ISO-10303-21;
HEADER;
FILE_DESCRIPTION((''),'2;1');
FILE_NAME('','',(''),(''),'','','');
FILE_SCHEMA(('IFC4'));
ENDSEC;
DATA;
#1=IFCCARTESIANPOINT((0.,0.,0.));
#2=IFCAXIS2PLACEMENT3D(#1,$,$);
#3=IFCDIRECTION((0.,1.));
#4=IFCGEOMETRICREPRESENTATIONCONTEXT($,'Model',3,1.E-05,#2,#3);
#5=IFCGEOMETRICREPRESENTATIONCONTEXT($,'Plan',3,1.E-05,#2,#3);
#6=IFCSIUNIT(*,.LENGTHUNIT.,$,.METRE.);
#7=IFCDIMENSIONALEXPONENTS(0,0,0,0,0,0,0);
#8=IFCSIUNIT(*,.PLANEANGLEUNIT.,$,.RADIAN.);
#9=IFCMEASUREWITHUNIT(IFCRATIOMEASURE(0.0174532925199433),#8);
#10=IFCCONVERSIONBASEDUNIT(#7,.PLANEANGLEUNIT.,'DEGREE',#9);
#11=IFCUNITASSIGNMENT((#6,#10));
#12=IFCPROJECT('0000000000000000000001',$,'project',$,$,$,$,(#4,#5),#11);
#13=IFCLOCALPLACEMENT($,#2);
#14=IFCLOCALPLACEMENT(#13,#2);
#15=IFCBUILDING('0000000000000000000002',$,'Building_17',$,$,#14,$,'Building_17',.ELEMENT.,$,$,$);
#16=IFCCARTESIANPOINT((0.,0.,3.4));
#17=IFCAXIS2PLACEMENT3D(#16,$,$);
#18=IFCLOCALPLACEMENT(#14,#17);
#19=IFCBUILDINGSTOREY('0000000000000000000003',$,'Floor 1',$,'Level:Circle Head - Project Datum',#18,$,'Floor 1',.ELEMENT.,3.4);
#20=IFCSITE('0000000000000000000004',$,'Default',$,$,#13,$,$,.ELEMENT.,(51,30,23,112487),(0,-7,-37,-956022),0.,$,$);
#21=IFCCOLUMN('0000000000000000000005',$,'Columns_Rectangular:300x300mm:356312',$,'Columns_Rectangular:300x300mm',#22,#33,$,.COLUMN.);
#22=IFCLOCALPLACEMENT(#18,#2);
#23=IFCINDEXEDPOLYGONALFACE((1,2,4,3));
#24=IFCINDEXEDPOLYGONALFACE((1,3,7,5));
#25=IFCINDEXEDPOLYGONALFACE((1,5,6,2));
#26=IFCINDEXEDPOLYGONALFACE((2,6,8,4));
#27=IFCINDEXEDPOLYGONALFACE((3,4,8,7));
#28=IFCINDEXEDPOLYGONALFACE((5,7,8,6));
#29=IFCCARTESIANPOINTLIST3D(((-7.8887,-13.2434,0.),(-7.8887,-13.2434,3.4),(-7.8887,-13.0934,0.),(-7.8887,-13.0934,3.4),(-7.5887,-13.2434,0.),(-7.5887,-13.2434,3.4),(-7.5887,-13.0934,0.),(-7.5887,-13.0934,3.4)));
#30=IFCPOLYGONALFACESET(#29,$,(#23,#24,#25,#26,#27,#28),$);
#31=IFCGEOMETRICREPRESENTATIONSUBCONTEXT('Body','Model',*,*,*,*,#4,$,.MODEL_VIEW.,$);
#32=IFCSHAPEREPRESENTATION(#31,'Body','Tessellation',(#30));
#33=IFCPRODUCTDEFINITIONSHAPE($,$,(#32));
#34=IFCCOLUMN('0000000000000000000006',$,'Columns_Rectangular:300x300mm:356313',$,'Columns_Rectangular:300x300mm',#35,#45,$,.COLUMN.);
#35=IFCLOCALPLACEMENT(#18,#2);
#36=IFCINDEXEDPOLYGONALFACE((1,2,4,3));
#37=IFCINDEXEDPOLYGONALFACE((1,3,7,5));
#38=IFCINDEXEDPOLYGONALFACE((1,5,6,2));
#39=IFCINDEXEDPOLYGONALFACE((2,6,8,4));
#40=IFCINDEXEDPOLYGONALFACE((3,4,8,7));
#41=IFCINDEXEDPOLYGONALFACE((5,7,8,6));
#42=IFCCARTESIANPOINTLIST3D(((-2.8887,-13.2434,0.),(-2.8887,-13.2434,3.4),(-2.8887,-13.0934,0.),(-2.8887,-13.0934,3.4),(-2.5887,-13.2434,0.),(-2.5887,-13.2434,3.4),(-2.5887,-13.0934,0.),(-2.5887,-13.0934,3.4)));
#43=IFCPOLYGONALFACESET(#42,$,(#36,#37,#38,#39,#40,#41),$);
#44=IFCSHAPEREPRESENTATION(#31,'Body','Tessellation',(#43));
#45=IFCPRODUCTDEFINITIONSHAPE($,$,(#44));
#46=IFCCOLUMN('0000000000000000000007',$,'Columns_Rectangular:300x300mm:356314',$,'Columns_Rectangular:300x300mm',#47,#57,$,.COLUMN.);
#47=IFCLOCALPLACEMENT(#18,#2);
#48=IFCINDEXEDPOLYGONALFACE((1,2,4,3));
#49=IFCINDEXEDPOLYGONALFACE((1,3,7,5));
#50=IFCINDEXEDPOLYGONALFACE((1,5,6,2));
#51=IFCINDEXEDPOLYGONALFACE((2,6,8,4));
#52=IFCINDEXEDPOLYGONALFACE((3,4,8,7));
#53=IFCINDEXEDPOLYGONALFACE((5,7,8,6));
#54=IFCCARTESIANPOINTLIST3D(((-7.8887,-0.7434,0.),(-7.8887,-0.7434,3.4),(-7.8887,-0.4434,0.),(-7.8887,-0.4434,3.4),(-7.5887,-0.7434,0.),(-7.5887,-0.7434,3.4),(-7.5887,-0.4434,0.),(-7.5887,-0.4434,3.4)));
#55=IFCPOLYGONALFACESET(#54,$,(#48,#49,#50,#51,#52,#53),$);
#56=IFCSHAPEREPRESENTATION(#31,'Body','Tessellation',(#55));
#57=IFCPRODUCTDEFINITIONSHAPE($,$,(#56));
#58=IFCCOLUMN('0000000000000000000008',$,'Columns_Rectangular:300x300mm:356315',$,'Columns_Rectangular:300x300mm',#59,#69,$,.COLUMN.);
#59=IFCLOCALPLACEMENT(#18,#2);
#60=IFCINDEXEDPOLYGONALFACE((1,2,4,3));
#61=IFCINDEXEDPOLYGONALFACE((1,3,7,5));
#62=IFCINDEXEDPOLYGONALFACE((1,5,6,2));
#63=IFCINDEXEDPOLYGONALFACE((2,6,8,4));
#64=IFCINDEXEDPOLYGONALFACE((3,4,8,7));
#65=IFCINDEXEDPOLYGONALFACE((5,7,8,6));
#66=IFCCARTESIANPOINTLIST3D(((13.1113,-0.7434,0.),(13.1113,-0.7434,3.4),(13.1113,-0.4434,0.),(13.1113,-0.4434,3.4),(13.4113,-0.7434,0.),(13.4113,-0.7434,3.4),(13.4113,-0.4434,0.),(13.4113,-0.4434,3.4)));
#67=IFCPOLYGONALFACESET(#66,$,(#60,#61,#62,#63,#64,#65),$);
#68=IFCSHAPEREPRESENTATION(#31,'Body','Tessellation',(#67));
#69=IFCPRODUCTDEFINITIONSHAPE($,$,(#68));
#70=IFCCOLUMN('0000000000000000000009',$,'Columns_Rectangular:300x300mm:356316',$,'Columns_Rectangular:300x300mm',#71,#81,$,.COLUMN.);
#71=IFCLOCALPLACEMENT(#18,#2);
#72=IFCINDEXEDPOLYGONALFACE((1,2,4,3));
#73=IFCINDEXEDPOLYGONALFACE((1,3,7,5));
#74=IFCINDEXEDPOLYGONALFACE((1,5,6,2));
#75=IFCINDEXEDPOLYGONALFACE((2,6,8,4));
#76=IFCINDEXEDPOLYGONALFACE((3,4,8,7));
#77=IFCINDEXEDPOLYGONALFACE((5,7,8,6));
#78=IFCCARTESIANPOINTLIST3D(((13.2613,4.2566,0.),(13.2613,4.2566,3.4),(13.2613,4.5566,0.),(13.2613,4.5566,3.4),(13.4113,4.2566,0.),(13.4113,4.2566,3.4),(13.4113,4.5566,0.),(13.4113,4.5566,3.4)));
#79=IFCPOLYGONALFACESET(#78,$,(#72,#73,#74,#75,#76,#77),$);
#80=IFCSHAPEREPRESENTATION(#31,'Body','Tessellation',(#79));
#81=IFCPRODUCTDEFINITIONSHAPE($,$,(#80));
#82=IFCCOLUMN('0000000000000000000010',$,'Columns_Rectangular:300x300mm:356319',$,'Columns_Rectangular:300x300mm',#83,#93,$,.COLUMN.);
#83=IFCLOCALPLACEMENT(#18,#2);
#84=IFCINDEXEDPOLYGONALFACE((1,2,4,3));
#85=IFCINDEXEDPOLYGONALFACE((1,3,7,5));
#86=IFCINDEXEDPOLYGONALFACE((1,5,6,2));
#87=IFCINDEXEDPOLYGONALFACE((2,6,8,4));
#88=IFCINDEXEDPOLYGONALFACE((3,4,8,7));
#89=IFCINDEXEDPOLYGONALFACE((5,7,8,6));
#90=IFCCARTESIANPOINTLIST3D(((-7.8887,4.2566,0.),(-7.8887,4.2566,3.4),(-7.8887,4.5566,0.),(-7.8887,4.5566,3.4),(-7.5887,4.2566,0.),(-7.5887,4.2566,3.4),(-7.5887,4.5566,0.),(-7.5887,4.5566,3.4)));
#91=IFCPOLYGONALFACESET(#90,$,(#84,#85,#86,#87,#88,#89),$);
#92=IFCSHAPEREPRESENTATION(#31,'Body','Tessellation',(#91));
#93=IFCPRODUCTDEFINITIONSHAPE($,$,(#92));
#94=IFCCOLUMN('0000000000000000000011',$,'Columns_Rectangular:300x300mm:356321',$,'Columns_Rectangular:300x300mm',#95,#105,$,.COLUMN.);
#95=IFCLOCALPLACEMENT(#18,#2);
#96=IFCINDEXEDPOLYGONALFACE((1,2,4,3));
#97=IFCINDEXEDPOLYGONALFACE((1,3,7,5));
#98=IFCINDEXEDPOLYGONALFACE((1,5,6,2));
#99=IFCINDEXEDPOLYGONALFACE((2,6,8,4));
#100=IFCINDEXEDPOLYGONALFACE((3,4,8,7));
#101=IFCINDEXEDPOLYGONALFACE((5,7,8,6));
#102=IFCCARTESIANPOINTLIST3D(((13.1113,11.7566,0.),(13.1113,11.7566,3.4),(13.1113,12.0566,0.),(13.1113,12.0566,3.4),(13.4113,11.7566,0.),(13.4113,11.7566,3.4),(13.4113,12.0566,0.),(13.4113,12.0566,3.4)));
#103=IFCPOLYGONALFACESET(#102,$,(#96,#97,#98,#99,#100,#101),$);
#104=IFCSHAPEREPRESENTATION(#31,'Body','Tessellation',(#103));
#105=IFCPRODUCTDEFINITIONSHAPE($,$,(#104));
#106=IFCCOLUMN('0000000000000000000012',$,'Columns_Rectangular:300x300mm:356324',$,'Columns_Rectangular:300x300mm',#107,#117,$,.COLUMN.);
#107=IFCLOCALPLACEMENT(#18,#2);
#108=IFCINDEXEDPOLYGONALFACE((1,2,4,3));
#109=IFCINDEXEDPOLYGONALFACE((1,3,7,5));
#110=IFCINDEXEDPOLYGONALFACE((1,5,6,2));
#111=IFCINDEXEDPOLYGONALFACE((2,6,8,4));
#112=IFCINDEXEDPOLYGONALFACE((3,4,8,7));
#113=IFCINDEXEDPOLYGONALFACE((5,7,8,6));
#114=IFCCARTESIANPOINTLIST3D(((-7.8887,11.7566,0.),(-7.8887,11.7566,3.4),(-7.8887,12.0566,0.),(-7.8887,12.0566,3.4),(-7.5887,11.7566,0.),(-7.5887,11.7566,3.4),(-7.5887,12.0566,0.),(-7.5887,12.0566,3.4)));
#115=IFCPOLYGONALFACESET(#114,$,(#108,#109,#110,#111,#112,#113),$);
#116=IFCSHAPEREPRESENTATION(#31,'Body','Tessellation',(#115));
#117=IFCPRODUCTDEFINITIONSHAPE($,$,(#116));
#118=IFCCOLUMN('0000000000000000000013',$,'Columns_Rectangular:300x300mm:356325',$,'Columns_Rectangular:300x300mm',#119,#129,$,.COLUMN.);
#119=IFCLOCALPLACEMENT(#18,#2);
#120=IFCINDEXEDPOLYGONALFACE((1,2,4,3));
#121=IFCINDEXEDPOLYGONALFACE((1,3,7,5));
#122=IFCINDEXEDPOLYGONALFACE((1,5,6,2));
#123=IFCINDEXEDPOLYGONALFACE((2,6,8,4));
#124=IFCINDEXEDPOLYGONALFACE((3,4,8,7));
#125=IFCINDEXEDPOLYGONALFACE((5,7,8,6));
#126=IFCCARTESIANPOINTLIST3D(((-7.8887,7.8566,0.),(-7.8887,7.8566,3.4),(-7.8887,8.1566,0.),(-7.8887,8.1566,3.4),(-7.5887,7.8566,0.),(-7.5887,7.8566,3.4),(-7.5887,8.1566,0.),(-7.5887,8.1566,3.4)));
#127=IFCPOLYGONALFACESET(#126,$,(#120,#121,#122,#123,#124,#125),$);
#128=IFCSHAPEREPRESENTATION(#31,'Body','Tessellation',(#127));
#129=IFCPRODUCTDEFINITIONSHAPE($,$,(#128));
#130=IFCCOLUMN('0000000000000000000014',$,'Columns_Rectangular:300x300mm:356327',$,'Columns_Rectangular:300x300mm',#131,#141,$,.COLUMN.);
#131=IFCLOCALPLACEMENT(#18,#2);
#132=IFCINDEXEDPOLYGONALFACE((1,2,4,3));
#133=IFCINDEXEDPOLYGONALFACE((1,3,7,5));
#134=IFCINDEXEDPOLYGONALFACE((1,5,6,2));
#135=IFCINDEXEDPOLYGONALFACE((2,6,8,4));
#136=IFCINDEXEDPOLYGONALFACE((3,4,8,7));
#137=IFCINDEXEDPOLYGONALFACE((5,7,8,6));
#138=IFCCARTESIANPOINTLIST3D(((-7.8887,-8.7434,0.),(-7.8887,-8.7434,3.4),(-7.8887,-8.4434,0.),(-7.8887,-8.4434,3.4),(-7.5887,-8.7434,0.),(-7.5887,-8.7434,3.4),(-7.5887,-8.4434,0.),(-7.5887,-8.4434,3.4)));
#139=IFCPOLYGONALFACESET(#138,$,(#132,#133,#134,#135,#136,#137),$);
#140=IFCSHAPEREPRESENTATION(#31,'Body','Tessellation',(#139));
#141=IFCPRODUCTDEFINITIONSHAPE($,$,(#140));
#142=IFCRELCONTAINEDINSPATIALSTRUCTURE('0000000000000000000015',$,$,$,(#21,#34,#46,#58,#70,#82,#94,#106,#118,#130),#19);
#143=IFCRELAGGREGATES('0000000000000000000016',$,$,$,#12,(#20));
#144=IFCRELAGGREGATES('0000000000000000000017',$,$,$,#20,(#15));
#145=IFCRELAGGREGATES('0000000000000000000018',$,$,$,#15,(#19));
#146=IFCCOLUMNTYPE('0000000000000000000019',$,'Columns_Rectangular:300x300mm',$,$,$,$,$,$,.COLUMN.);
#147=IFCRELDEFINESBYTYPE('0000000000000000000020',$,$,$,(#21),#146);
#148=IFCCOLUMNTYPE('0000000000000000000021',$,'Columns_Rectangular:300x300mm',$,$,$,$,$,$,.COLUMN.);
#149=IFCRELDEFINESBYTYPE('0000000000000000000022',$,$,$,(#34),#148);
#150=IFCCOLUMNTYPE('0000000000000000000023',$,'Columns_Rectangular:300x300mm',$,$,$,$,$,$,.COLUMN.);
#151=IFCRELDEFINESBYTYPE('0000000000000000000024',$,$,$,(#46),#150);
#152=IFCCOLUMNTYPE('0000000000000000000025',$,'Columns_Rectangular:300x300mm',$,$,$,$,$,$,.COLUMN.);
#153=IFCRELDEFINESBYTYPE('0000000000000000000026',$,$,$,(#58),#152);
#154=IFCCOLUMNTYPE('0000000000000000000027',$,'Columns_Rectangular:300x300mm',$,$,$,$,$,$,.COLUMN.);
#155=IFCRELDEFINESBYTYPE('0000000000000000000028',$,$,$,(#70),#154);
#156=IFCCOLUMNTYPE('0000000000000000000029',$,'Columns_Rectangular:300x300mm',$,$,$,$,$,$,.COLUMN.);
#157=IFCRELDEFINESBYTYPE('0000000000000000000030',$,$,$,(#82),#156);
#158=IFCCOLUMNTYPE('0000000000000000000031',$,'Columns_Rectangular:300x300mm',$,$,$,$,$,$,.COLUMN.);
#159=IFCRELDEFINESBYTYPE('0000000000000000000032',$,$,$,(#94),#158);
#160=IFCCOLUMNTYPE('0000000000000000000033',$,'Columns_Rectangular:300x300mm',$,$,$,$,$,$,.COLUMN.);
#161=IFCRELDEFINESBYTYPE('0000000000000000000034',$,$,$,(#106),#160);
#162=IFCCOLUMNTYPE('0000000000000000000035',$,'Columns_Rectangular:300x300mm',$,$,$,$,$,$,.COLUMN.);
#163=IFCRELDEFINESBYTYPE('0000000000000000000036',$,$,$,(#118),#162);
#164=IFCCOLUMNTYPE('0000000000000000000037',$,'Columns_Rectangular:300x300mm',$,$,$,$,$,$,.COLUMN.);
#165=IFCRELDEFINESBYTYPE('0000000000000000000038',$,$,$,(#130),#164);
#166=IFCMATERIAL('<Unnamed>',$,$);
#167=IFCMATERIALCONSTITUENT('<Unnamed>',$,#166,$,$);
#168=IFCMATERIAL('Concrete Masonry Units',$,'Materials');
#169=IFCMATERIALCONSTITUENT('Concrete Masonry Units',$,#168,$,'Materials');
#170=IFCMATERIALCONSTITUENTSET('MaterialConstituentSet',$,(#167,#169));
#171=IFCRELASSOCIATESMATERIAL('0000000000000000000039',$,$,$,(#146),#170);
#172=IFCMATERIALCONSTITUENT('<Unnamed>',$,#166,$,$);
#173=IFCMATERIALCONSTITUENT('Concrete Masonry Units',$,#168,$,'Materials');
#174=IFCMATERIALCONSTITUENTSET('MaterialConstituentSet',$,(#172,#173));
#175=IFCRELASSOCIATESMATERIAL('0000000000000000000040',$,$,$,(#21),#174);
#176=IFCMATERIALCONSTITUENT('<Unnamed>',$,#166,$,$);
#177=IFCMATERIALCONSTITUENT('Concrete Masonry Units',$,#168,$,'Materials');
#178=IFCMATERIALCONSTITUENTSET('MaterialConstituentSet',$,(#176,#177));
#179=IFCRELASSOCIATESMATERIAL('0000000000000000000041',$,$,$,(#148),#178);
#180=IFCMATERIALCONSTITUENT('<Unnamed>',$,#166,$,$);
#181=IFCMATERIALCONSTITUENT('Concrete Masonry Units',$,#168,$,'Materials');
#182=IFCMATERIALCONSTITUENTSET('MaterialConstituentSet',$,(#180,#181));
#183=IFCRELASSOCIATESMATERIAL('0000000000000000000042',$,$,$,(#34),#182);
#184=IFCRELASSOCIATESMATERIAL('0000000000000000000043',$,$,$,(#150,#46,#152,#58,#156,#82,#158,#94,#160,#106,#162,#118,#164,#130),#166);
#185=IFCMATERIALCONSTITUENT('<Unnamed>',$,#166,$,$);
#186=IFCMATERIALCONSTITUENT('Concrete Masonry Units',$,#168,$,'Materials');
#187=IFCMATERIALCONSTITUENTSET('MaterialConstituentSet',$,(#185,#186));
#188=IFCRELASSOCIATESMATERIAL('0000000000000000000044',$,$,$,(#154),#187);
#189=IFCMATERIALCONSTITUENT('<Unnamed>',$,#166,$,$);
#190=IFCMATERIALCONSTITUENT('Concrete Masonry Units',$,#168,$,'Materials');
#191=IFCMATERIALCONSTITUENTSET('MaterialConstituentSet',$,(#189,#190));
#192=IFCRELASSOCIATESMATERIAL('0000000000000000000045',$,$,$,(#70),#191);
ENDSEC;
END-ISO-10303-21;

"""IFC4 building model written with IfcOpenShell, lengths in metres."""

from ifc_helpers import new_model, entity, si_unit, converted_unit, direction, frame, origin, place, context, subcontext, project, spatial, indexed_curve, outline, extrude, source, transform, mapped, material, constituent, constituent_set, type_object, type_shapes, element, save


model = new_model("IFC4")

# Units and contexts
model_context = context("Model", 3, precision=1e-05, world=origin(), true_north=direction((0.0, 1.0)))
plan_context = context("Plan", 3, precision=1e-05, world=origin(), true_north=direction((0.0, 1.0)))
body_context = subcontext(model_context, "Body", "Model", "MODEL_VIEW")
ifc_project = project(units=[si_unit("LENGTHUNIT", "METRE"), converted_unit("PLANEANGLEUNIT", "DEGREE", entity("IfcRatioMeasure", 0.0174532925199433), si_unit("PLANEANGLEUNIT", "RADIAN"), dimensions=[0, 0, 0, 0, 0, 0, 0])], contexts=[model_context, plan_context])

# Site, building, storey
site_placement = place(None, origin())
site = spatial("IfcSite", under=ifc_project, at=site_placement, Name="Default", CompositionType="ELEMENT", RefLatitude=(51, 30, 23, 112487), RefLongitude=(0, -7, -37, -956022), RefElevation=0.0)
building_placement = place(site_placement, origin())
building = spatial("IfcBuilding", under=site, at=building_placement, Name="Building_17", LongName="Building_17", CompositionType="ELEMENT")
storey_placement = place(building_placement, frame((0.0, 0.0, 3.4)))
storey = spatial("IfcBuildingStorey", under=building, at=storey_placement, Name="Floor 1", ObjectType="Level:Circle Head - Project Datum", LongName="Floor 1", CompositionType="ELEMENT", Elevation=3.4)

# Columns
ifc_material_1 = material(Name="<Unnamed>")
ifc_constituent_1 = constituent(ifc_material_1, Name="<Unnamed>")
ifc_material_2 = material(Name="Concrete Masonry Units", Category="Materials")
ifc_constituent_2 = constituent(ifc_material_2, Name="Concrete Masonry Units", Category="Materials")
ifc_constituent_set_1 = constituent_set(constituents=[ifc_constituent_1, ifc_constituent_2], Name="MaterialConstituentSet")
ifc_constituent_3 = constituent(ifc_material_1, Name="<Unnamed>")
ifc_constituent_4 = constituent(ifc_material_2, Name="Concrete Masonry Units", Category="Materials")
ifc_constituent_set_2 = constituent_set(constituents=[ifc_constituent_3, ifc_constituent_4], Name="MaterialConstituentSet")
column_type_1 = type_object("IfcColumnType", Name="Columns_Rectangular:300x300mm", PredefinedType="COLUMN", material=ifc_constituent_set_2)
shared_shape_1 = source(origin(), body_context, "Body", "SweptSolid", [
    extrude(outline(indexed_curve([(-0.075, -0.15), (0.075, -0.15), (0.075, 0.15), (-0.075, 0.15), (-0.075, -0.15)], self_intersect=False)), frame((-7.7387, -13.1684, 3.4), z_axis=(0.0, 0.0, 1.0), x_axis=(0.0, -1.0, 0.0)), (0.0, 0.0, 1.0), 3.4),
])
type_shapes(column_type_1, [shared_shape_1])
column_1_placement = place(storey_placement, frame((0.0, 0.0, -3.4)))
element("IfcColumn", 1, at=column_1_placement, inside=storey, type_object=column_type_1, material=ifc_constituent_set_1, Name="Columns_Rectangular:300x300mm:356312", ObjectType="Columns_Rectangular:300x300mm", PredefinedType="COLUMN", context=body_context, shape_type="MappedRepresentation", body=[
    mapped(shared_shape_1, transform((0.0, 0.0, 0.0), scale=1.0)),
])
ifc_constituent_5 = constituent(ifc_material_1, Name="<Unnamed>")
ifc_constituent_6 = constituent(ifc_material_2, Name="Concrete Masonry Units", Category="Materials")
ifc_constituent_set_3 = constituent_set(constituents=[ifc_constituent_5, ifc_constituent_6], Name="MaterialConstituentSet")
ifc_constituent_7 = constituent(ifc_material_1, Name="<Unnamed>")
ifc_constituent_8 = constituent(ifc_material_2, Name="Concrete Masonry Units", Category="Materials")
ifc_constituent_set_4 = constituent_set(constituents=[ifc_constituent_7, ifc_constituent_8], Name="MaterialConstituentSet")
column_type_2 = type_object("IfcColumnType", Name="Columns_Rectangular:300x300mm", PredefinedType="COLUMN", material=ifc_constituent_set_4)
shared_shape_2 = source(origin(), body_context, "Body", "SweptSolid", [
    extrude(outline(indexed_curve([(-0.075, -0.15), (0.075, -0.15), (0.075, 0.15), (-0.075, 0.15), (-0.075, -0.15)], self_intersect=False)), frame((-2.7387, -13.1684, 3.4), z_axis=(0.0, 0.0, 1.0), x_axis=(0.0, -1.0, 0.0)), (0.0, 0.0, 1.0), 3.4),
])
type_shapes(column_type_2, [shared_shape_2])
column_2_placement = place(storey_placement, frame((0.0, 0.0, -3.4)))
element("IfcColumn", 2, at=column_2_placement, inside=storey, type_object=column_type_2, material=ifc_constituent_set_3, Name="Columns_Rectangular:300x300mm:356313", ObjectType="Columns_Rectangular:300x300mm", PredefinedType="COLUMN", context=body_context, shape_type="MappedRepresentation", body=[
    mapped(shared_shape_2, transform((0.0, 0.0, 0.0), scale=1.0)),
])
column_type_3 = type_object("IfcColumnType", Name="Columns_Rectangular:300x300mm", PredefinedType="COLUMN", material=ifc_material_1)
shared_shape_3 = source(origin(), body_context, "Body", "SweptSolid", [
    extrude(outline(indexed_curve([(-0.15, -0.15), (0.15, -0.15), (0.15, 0.15), (-0.15, 0.15), (-0.15, -0.15)], self_intersect=False)), frame((-7.7387, -0.5934, 3.4), z_axis=(0.0, 0.0, 1.0), x_axis=(0.0, -1.0, 0.0)), (0.0, 0.0, 1.0), 3.4),
])
type_shapes(column_type_3, [shared_shape_3])
column_3_placement = place(storey_placement, frame((0.0, 0.0, -3.4)))
element("IfcColumn", 3, at=column_3_placement, inside=storey, type_object=column_type_3, material=ifc_material_1, Name="Columns_Rectangular:300x300mm:356314", ObjectType="Columns_Rectangular:300x300mm", PredefinedType="COLUMN", context=body_context, shape_type="MappedRepresentation", body=[
    mapped(shared_shape_3, transform((0.0, 0.0, 0.0), scale=1.0)),
])
column_type_4 = type_object("IfcColumnType", Name="Columns_Rectangular:300x300mm", PredefinedType="COLUMN", material=ifc_material_1)
shared_shape_4 = source(origin(), body_context, "Body", "SweptSolid", [
    extrude(outline(indexed_curve([(-0.15, -0.15), (0.15, -0.15), (0.15, 0.15), (-0.15, 0.15), (-0.15, -0.15)], self_intersect=False)), frame((13.2613, -0.5934, 3.4), z_axis=(0.0, 0.0, 1.0), x_axis=(0.0, -1.0, 0.0)), (0.0, 0.0, 1.0), 3.4),
])
type_shapes(column_type_4, [shared_shape_4])
column_4_placement = place(storey_placement, frame((0.0, 0.0, -3.4)))
element("IfcColumn", 4, at=column_4_placement, inside=storey, type_object=column_type_4, material=ifc_material_1, Name="Columns_Rectangular:300x300mm:356315", ObjectType="Columns_Rectangular:300x300mm", PredefinedType="COLUMN", context=body_context, shape_type="MappedRepresentation", body=[
    mapped(shared_shape_4, transform((0.0, 0.0, 0.0), scale=1.0)),
])
ifc_constituent_9 = constituent(ifc_material_1, Name="<Unnamed>")
ifc_constituent_10 = constituent(ifc_material_2, Name="Concrete Masonry Units", Category="Materials")
ifc_constituent_set_5 = constituent_set(constituents=[ifc_constituent_9, ifc_constituent_10], Name="MaterialConstituentSet")
ifc_constituent_11 = constituent(ifc_material_1, Name="<Unnamed>")
ifc_constituent_12 = constituent(ifc_material_2, Name="Concrete Masonry Units", Category="Materials")
ifc_constituent_set_6 = constituent_set(constituents=[ifc_constituent_11, ifc_constituent_12], Name="MaterialConstituentSet")
column_type_5 = type_object("IfcColumnType", Name="Columns_Rectangular:300x300mm", PredefinedType="COLUMN", material=ifc_constituent_set_6)
shared_shape_5 = source(origin(), body_context, "Body", "SweptSolid", [
    extrude(outline(indexed_curve([(-0.15, -0.075), (0.15, -0.075), (0.15, 0.075), (-0.15, 0.075), (-0.15, -0.075)], self_intersect=False)), frame((13.3363, 4.4066, 3.4), z_axis=(0.0, 0.0, 1.0), x_axis=(0.0, -1.0, 0.0)), (0.0, 0.0, 1.0), 3.4),
])
type_shapes(column_type_5, [shared_shape_5])
column_5_placement = place(storey_placement, frame((0.0, 0.0, -3.4)))
element("IfcColumn", 5, at=column_5_placement, inside=storey, type_object=column_type_5, material=ifc_constituent_set_5, Name="Columns_Rectangular:300x300mm:356316", ObjectType="Columns_Rectangular:300x300mm", PredefinedType="COLUMN", context=body_context, shape_type="MappedRepresentation", body=[
    mapped(shared_shape_5, transform((0.0, 0.0, 0.0), scale=1.0)),
])
column_type_6 = type_object("IfcColumnType", Name="Columns_Rectangular:300x300mm", PredefinedType="COLUMN", material=ifc_material_1)
shared_shape_6 = source(origin(), body_context, "Body", "SweptSolid", [
    extrude(outline(indexed_curve([(-0.15, -0.15), (0.15, -0.15), (0.15, 0.15), (-0.15, 0.15), (-0.15, -0.15)], self_intersect=False)), frame((-7.7387, 4.4066, 3.4), z_axis=(0.0, 0.0, 1.0), x_axis=(0.0, -1.0, 0.0)), (0.0, 0.0, 1.0), 3.4),
])
type_shapes(column_type_6, [shared_shape_6])
column_6_placement = place(storey_placement, frame((0.0, 0.0, -3.4)))
element("IfcColumn", 6, at=column_6_placement, inside=storey, type_object=column_type_6, material=ifc_material_1, Name="Columns_Rectangular:300x300mm:356319", ObjectType="Columns_Rectangular:300x300mm", PredefinedType="COLUMN", context=body_context, shape_type="MappedRepresentation", body=[
    mapped(shared_shape_6, transform((0.0, 0.0, 0.0), scale=1.0)),
])
column_type_7 = type_object("IfcColumnType", Name="Columns_Rectangular:300x300mm", PredefinedType="COLUMN", material=ifc_material_1)
shared_shape_7 = source(origin(), body_context, "Body", "SweptSolid", [
    extrude(outline(indexed_curve([(-0.15, -0.15), (0.15, -0.15), (0.15, 0.15), (-0.15, 0.15), (-0.15, -0.15)], self_intersect=False)), frame((13.2613, 11.9066, 3.4), z_axis=(0.0, 0.0, 1.0), x_axis=(0.0, -1.0, 0.0)), (0.0, 0.0, 1.0), 3.4),
])
type_shapes(column_type_7, [shared_shape_7])
column_7_placement = place(storey_placement, frame((0.0, 0.0, -3.4)))
element("IfcColumn", 7, at=column_7_placement, inside=storey, type_object=column_type_7, material=ifc_material_1, Name="Columns_Rectangular:300x300mm:356321", ObjectType="Columns_Rectangular:300x300mm", PredefinedType="COLUMN", context=body_context, shape_type="MappedRepresentation", body=[
    mapped(shared_shape_7, transform((0.0, 0.0, 0.0), scale=1.0)),
])
column_type_8 = type_object("IfcColumnType", Name="Columns_Rectangular:300x300mm", PredefinedType="COLUMN", material=ifc_material_1)
shared_shape_8 = source(origin(), body_context, "Body", "SweptSolid", [
    extrude(outline(indexed_curve([(-0.15, -0.15), (0.15, -0.15), (0.15, 0.15), (-0.15, 0.15), (-0.15, -0.15)], self_intersect=False)), frame((-7.7387, 11.9066, 3.4), z_axis=(0.0, 0.0, 1.0), x_axis=(0.0, -1.0, 0.0)), (0.0, 0.0, 1.0), 3.4),
])
type_shapes(column_type_8, [shared_shape_8])
column_8_placement = place(storey_placement, frame((0.0, 0.0, -3.4)))
element("IfcColumn", 8, at=column_8_placement, inside=storey, type_object=column_type_8, material=ifc_material_1, Name="Columns_Rectangular:300x300mm:356324", ObjectType="Columns_Rectangular:300x300mm", PredefinedType="COLUMN", context=body_context, shape_type="MappedRepresentation", body=[
    mapped(shared_shape_8, transform((0.0, 0.0, 0.0), scale=1.0)),
])
column_type_9 = type_object("IfcColumnType", Name="Columns_Rectangular:300x300mm", PredefinedType="COLUMN", material=ifc_material_1)
shared_shape_9 = source(origin(), body_context, "Body", "SweptSolid", [
    extrude(outline(indexed_curve([(-0.15, -0.15), (0.15, -0.15), (0.15, 0.15), (-0.15, 0.15), (-0.15, -0.15)], self_intersect=False)), frame((-7.7387, 8.0066, 3.4), z_axis=(0.0, 0.0, 1.0), x_axis=(0.0, -1.0, 0.0)), (0.0, 0.0, 1.0), 3.4),
])
type_shapes(column_type_9, [shared_shape_9])
column_9_placement = place(storey_placement, frame((0.0, 0.0, -3.4)))
element("IfcColumn", 9, at=column_9_placement, inside=storey, type_object=column_type_9, material=ifc_material_1, Name="Columns_Rectangular:300x300mm:356325", ObjectType="Columns_Rectangular:300x300mm", PredefinedType="COLUMN", context=body_context, shape_type="MappedRepresentation", body=[
    mapped(shared_shape_9, transform((0.0, 0.0, 0.0), scale=1.0)),
])
column_type_10 = type_object("IfcColumnType", Name="Columns_Rectangular:300x300mm", PredefinedType="COLUMN", material=ifc_material_1)
shared_shape_10 = source(origin(), body_context, "Body", "SweptSolid", [
    extrude(outline(indexed_curve([(-0.15, -0.15), (0.15, -0.15), (0.15, 0.15), (-0.15, 0.15), (-0.15, -0.15)], self_intersect=False)), frame((-7.7387, -8.5934, 3.4), z_axis=(0.0, 0.0, 1.0), x_axis=(0.0, -1.0, 0.0)), (0.0, 0.0, 1.0), 3.4),
])
type_shapes(column_type_10, [shared_shape_10])
column_10_placement = place(storey_placement, frame((0.0, 0.0, -3.4)))
element("IfcColumn", 10, at=column_10_placement, inside=storey, type_object=column_type_10, material=ifc_material_1, Name="Columns_Rectangular:300x300mm:356327", ObjectType="Columns_Rectangular:300x300mm", PredefinedType="COLUMN", context=body_context, shape_type="MappedRepresentation", body=[
    mapped(shared_shape_10, transform((0.0, 0.0, 0.0), scale=1.0)),
])

save(model, "model.ifc")
